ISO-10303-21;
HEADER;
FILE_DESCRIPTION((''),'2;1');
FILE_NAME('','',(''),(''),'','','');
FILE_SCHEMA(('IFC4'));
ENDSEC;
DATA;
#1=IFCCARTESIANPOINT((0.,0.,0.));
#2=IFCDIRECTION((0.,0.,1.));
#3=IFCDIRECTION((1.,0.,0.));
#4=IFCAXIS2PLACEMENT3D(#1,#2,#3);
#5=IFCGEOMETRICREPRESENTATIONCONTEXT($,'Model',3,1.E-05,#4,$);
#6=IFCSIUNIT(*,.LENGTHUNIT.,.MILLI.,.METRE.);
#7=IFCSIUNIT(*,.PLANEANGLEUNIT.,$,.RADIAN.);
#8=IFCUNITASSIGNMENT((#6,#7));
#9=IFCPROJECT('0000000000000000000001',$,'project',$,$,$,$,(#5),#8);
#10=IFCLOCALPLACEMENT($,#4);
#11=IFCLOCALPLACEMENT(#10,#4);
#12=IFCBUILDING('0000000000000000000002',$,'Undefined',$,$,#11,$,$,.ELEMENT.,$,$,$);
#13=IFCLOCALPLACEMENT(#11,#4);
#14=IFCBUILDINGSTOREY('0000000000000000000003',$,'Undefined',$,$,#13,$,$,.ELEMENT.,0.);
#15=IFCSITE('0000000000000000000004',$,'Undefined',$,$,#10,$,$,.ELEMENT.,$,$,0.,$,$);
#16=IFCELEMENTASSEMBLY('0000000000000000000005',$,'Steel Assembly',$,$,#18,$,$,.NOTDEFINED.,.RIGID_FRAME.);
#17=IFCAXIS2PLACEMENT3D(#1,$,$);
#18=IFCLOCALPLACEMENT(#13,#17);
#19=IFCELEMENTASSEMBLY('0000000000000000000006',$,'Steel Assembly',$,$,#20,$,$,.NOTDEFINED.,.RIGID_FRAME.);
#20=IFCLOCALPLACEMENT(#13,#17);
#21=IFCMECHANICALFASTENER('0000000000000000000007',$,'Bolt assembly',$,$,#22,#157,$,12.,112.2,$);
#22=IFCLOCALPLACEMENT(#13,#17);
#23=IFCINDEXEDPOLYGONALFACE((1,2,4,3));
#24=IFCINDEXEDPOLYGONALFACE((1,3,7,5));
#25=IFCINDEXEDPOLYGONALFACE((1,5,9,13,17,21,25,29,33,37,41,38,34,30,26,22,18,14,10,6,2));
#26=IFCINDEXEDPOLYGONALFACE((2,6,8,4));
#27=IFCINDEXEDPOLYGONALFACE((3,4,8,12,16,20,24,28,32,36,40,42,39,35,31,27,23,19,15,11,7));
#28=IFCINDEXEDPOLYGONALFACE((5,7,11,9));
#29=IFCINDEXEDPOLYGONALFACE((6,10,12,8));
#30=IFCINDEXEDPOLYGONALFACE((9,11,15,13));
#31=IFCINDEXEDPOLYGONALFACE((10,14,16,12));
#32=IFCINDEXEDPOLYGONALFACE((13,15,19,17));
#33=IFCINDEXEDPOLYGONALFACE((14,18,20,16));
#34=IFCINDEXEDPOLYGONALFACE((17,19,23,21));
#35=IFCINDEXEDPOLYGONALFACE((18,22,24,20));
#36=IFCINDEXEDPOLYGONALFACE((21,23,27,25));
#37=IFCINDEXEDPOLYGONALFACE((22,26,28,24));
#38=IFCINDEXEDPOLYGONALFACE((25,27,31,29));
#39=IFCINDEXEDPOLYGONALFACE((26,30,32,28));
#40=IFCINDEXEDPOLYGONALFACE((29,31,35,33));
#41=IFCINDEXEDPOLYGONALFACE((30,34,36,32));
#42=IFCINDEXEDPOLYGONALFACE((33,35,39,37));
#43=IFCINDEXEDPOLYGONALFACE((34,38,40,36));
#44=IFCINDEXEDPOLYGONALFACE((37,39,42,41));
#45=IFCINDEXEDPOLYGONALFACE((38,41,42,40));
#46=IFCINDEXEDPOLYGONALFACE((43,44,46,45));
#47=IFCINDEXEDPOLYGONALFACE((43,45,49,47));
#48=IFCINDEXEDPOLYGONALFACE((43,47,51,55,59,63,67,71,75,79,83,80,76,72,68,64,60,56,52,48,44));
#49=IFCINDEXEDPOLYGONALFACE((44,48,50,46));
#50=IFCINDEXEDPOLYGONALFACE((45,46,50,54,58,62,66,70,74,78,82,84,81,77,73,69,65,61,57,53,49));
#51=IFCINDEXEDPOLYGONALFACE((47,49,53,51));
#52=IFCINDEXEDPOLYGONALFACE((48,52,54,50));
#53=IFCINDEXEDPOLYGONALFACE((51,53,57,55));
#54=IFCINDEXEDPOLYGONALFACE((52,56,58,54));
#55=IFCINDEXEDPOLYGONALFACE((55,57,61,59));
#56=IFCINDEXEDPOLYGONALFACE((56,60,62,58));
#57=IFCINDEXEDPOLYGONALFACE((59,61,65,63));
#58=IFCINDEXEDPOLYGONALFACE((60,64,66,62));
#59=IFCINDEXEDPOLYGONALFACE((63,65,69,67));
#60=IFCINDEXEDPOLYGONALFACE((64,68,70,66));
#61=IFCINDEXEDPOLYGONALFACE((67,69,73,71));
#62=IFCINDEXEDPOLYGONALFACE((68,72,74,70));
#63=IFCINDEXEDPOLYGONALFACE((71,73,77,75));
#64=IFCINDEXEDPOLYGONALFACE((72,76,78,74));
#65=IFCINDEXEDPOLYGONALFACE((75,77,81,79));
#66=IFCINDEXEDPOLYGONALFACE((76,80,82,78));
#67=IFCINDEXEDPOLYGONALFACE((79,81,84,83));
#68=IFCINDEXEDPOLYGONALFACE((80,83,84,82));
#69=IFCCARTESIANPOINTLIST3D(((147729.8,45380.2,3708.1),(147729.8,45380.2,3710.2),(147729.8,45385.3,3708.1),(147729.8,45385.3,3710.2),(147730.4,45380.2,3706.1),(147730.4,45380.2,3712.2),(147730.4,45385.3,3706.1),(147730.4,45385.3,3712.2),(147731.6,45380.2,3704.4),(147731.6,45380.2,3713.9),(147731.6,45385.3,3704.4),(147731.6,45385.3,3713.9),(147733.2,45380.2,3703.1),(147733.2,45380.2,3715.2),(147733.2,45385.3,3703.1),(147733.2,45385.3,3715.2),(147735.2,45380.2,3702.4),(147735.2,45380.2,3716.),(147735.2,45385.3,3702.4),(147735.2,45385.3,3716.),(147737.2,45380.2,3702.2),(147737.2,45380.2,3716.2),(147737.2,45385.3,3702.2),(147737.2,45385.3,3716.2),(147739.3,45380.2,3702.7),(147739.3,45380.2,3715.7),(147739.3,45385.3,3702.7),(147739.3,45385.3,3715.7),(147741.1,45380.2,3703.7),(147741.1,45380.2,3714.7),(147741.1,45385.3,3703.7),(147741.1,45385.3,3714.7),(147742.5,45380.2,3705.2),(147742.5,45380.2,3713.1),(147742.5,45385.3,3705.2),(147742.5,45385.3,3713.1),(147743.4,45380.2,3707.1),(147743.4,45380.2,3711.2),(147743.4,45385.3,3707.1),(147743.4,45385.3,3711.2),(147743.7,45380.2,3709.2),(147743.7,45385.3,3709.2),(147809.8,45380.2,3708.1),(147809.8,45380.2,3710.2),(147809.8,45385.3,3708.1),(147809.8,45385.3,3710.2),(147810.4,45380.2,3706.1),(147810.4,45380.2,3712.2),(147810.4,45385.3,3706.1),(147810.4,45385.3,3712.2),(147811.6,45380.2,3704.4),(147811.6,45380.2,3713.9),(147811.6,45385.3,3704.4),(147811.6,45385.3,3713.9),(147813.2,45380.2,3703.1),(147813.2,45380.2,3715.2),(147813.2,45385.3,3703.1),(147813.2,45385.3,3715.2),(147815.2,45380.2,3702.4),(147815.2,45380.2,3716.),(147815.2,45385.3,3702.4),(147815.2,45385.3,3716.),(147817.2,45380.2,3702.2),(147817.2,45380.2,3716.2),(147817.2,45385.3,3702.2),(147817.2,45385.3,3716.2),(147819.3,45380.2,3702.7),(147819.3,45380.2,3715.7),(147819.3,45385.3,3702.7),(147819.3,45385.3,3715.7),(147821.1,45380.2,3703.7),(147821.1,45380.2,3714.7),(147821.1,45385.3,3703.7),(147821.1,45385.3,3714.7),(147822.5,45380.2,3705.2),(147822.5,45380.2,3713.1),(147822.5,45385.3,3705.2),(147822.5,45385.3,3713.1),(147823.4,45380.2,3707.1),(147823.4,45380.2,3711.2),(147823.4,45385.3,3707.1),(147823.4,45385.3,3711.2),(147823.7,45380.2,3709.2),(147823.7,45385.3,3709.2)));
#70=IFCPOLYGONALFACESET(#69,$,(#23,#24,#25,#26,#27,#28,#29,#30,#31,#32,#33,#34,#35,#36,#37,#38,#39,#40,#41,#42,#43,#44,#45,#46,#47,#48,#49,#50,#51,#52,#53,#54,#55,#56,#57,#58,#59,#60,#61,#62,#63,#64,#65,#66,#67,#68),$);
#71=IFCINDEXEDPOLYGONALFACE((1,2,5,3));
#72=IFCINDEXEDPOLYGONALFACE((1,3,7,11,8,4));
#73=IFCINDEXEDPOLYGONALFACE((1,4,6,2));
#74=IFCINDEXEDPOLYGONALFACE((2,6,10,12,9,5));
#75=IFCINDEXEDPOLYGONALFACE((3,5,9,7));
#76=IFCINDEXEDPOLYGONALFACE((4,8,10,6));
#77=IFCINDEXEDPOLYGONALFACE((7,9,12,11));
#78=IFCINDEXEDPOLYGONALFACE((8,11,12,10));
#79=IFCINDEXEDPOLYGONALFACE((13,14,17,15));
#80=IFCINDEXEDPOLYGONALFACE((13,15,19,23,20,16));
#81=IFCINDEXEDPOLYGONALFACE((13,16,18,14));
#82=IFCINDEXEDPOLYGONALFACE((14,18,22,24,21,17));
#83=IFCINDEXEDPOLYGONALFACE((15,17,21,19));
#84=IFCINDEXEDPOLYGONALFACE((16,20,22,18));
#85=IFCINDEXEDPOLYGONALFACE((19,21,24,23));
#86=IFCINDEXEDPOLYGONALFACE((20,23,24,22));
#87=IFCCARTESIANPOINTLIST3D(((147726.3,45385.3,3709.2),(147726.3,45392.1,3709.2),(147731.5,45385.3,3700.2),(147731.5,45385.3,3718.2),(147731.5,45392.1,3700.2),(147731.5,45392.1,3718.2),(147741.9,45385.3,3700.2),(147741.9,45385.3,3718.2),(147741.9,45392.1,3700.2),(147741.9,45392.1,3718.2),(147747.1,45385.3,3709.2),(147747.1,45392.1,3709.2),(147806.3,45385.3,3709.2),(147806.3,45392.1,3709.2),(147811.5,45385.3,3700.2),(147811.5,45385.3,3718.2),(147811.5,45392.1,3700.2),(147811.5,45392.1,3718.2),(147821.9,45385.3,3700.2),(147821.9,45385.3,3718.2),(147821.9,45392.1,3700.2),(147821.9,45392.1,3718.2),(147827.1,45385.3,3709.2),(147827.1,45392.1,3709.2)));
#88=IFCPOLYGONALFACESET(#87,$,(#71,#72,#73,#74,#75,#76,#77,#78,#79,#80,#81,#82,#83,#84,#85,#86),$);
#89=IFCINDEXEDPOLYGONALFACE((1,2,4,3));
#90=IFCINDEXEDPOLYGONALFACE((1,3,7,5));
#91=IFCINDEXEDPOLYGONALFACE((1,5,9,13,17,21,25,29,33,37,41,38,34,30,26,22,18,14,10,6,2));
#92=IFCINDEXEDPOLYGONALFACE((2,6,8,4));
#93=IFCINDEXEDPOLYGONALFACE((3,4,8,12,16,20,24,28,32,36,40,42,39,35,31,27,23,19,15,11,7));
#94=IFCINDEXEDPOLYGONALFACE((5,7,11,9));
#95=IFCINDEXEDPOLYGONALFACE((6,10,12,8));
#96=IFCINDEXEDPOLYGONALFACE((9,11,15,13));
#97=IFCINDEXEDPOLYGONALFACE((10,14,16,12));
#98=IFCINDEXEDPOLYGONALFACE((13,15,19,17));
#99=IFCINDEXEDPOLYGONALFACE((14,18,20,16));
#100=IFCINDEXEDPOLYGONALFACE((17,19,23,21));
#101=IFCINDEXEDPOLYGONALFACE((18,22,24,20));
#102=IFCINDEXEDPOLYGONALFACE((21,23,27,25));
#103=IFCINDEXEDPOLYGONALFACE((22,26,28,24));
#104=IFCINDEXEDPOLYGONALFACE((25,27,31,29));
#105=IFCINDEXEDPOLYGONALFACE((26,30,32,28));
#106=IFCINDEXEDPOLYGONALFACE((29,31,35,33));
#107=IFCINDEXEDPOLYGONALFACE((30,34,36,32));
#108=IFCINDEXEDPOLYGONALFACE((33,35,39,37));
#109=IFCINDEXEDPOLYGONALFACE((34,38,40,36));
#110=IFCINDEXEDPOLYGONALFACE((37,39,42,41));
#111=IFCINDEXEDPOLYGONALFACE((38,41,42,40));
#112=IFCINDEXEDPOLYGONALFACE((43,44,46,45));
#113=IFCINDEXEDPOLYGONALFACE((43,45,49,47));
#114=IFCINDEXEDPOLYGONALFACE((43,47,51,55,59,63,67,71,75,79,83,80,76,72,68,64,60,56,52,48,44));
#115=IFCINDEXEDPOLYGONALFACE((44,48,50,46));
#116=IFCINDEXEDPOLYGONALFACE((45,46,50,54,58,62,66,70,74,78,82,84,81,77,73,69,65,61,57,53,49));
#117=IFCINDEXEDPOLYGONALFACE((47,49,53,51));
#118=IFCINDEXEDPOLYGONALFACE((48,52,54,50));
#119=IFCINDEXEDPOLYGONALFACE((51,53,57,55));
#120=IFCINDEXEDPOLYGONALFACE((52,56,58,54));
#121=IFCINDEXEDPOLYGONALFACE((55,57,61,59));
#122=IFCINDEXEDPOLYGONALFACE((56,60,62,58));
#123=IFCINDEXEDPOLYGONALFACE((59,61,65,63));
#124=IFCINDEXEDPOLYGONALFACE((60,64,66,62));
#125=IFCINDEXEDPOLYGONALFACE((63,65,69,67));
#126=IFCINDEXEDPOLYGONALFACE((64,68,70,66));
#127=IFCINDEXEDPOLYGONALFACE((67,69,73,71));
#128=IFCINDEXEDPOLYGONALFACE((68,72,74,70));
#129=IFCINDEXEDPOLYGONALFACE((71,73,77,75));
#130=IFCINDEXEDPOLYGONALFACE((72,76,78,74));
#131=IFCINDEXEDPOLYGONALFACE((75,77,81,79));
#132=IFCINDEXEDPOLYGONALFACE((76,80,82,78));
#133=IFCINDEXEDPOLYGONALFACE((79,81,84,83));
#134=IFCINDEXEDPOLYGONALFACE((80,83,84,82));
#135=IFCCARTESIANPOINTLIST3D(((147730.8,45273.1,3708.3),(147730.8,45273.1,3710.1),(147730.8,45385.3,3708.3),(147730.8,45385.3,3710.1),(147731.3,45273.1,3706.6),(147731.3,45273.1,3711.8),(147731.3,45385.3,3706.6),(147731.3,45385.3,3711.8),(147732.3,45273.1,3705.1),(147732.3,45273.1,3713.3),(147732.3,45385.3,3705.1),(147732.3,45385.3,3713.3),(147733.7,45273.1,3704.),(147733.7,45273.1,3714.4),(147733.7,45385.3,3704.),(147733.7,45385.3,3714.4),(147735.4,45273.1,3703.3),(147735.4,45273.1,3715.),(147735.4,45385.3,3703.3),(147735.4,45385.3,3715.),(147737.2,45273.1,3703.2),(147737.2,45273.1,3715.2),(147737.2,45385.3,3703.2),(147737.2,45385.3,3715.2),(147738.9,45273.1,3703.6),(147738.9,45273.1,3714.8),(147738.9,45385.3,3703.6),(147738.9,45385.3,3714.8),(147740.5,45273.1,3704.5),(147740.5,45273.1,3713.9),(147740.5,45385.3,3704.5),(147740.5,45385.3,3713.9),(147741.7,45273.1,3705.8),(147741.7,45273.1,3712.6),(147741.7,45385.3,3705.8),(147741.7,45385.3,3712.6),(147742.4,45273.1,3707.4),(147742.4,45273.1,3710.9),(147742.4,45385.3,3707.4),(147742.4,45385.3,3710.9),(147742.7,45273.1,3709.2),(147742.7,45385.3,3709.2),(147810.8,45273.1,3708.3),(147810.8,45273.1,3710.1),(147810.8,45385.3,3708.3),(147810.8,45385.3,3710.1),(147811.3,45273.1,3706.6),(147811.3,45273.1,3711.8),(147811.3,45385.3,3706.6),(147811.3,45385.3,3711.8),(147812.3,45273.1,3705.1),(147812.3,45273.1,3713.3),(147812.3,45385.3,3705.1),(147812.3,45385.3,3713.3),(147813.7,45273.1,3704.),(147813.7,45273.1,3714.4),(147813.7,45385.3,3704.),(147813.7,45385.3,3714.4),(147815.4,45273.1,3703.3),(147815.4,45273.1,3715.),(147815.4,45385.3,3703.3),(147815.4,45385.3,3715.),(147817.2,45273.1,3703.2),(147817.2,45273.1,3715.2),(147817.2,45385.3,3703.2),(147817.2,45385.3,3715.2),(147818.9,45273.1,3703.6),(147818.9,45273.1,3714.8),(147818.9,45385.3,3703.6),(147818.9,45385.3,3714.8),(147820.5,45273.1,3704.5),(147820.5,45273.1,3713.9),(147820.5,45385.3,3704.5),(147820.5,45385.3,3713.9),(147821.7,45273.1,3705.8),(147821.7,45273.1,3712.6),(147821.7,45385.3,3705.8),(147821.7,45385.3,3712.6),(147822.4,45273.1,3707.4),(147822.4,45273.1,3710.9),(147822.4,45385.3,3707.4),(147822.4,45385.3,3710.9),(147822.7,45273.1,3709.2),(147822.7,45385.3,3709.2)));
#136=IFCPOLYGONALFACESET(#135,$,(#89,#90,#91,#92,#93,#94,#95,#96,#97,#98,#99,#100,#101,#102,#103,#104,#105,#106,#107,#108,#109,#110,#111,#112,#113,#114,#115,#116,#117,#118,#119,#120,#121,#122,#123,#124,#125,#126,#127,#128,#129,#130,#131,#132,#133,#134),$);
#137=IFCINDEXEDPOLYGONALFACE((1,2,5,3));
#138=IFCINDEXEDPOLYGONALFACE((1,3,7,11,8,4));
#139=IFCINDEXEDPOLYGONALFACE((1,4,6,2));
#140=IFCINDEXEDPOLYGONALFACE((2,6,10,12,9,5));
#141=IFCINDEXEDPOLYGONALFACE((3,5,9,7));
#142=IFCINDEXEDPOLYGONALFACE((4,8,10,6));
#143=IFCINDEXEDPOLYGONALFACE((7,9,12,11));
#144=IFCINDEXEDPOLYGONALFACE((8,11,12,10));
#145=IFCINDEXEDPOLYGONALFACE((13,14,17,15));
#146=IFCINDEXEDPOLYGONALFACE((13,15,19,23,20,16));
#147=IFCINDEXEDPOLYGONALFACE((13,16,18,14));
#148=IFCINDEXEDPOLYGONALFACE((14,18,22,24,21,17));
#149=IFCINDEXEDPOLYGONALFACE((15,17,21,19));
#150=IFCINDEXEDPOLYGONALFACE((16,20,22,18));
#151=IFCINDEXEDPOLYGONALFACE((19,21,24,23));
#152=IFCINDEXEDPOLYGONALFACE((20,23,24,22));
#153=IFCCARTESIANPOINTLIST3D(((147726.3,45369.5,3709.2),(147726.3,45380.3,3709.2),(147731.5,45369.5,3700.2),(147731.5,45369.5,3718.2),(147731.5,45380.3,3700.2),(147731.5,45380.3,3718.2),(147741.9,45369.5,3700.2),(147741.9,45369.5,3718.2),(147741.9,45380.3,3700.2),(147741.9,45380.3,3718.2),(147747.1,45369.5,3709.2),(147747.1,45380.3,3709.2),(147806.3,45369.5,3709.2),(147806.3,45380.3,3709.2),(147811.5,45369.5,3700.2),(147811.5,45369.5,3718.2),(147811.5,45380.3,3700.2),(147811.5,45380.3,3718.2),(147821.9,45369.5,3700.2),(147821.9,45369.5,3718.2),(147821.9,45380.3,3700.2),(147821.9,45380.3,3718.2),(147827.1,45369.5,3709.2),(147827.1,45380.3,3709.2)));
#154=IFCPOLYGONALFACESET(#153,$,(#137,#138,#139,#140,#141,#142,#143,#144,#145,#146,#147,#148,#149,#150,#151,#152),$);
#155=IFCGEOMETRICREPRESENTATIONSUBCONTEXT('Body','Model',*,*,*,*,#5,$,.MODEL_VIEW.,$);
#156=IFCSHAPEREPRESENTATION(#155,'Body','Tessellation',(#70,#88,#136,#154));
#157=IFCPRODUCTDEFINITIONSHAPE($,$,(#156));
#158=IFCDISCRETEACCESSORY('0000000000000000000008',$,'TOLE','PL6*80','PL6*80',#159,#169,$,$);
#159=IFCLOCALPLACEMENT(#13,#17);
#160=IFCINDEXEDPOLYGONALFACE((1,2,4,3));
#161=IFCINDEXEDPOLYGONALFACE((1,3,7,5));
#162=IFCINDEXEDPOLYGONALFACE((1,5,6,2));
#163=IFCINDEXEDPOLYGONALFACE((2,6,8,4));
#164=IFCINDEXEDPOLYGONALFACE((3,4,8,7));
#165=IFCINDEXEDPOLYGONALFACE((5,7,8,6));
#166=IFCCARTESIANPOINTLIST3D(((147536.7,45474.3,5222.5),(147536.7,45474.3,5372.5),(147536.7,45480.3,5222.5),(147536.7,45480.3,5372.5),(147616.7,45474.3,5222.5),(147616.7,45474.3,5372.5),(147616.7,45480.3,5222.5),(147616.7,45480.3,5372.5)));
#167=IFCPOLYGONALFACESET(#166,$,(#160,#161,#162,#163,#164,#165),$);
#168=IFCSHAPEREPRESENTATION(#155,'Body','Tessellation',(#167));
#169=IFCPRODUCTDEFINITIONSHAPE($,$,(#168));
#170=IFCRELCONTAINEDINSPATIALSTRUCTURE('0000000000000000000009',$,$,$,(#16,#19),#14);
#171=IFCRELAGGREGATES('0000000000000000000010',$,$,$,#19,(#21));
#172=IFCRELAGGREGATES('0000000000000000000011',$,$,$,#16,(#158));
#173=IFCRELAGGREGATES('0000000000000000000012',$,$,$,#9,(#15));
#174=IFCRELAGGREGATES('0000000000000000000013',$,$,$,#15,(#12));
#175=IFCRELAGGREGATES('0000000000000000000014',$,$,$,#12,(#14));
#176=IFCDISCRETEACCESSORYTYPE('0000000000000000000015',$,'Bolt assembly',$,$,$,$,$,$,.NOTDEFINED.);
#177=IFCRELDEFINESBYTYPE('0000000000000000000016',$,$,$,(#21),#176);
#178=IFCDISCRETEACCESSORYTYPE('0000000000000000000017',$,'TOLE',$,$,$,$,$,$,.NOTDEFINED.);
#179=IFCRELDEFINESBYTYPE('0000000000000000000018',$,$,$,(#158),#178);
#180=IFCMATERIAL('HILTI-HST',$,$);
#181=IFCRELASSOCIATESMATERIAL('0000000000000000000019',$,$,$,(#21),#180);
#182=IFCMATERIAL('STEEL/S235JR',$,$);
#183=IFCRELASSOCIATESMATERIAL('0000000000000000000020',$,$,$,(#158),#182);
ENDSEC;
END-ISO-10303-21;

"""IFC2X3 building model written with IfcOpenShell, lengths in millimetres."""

from ifc_helpers import new_model, si_unit, frame, origin_with_axes, origin_2d_with_axis, place, context, subcontext, project, spatial, polyline, circle, outline, extrude, source, transform, mapped, material, type_object, element, aggregate, save


model = new_model("IFC2X3")

# Units and contexts
model_context = context("Model", 3, precision=1e-05, world=origin_with_axes())
body_context = subcontext(model_context, "Body", "Model", "MODEL_VIEW")
ifc_project = project(units=[si_unit("LENGTHUNIT", "METRE", prefix="MILLI"), si_unit("PLANEANGLEUNIT", "RADIAN")], contexts=[model_context])

# Site, building, storey
site_placement = place(None, origin_with_axes())
site = spatial("IfcSite", under=ifc_project, at=site_placement, Name="Undefined", CompositionType="ELEMENT", RefElevation=0.0)
building_placement = place(site_placement, origin_with_axes())
building = spatial("IfcBuilding", under=site, at=building_placement, Name="Undefined", CompositionType="ELEMENT")
storey_placement = place(building_placement, origin_with_axes())
storey = spatial("IfcBuildingStorey", under=building, at=storey_placement, Name="Undefined", CompositionType="ELEMENT", Elevation=0.0)

# Element assembly
ifc_material_1 = material(Name="STEEL/S235JR")
assembly_1_placement = place(storey_placement, origin_with_axes())
assembly_1 = element("IfcElementAssembly", 1, at=assembly_1_placement, inside=storey, Name="Steel Assembly", AssemblyPlace="NOTDEFINED", PredefinedType="RIGID_FRAME")

# Element assembly
assembly_2_placement = place(storey_placement, origin_with_axes())
assembly_2 = element("IfcElementAssembly", 2, at=assembly_2_placement, inside=storey, Name="Steel Assembly", AssemblyPlace="NOTDEFINED", PredefinedType="RIGID_FRAME")

# Mechanical fastener
ifc_material_2 = material(Name="HILTI-HST")
discrete_accessory_type_1 = type_object("IfcDiscreteAccessoryType", Name="Bolt assembly")
shared_shape_1 = source(origin_with_axes(), body_context, "Body", "SweptSolid", [
    extrude(circle(Radius=7.0, at=origin_2d_with_axis()), frame((0.0, 0.0, 0.0), z_axis=(0.0, 1.0, 0.0), x_axis=(1.0, 0.0, 0.0)), (0.0, 0.0, 1.0), 5.1),
    extrude(outline(polyline([(10.4, 0.0), (5.2, 9.0), (-5.2, 9.0), (-10.4, 0.0), (-5.2, -9.0), (5.2, -9.0), (10.4, 0.0)])), frame((0.0, -6.8, 0.0), z_axis=(0.0, 1.0, 0.0), x_axis=(1.0, 0.0, 0.0)), (0.0, 0.0, 1.0), 6.8),
    extrude(circle(Radius=6.0, at=origin_2d_with_axis()), frame((0.0, 0.0, 0.0), z_axis=(0.0, 1.0, 0.0), x_axis=(1.0, 0.0, 0.0)), (0.0, 0.0, 1.0), 112.2),
    extrude(outline(polyline([(10.4, 0.0), (5.2, 9.0), (-5.2, 9.0), (-10.4, 0.0), (-5.2, -9.0), (5.2, -9.0), (10.4, 0.0)])), frame((0.0, 5.0, 0.0), z_axis=(0.0, 1.0, 0.0), x_axis=(1.0, 0.0, 0.0)), (0.0, 0.0, 1.0), 10.8),
])
mechanical_fastener_1_placement = place(assembly_2_placement, frame((147736.7, 45385.3, 3709.2), z_axis=(0.0, 0.0, -1.0), x_axis=(1.0, 0.0, 0.0)))
mechanical_fastener_1 = element("IfcMechanicalFastener", 3, at=mechanical_fastener_1_placement, type_object=discrete_accessory_type_1, material=ifc_material_2, Name="Bolt assembly", NominalDiameter=12.0, NominalLength=112.2, context=body_context, shape_type="MappedRepresentation", body=[
    mapped(shared_shape_1, transform((0.0, 0.0, 0.0))),
    mapped(shared_shape_1, transform((80.0, 0.0, 0.0))),
])
aggregate(assembly_2, [mechanical_fastener_1])

# Discrete accessory
discrete_accessory_type_2 = type_object("IfcDiscreteAccessoryType", Name="TOLE")
discrete_accessory_1_placement = place(assembly_1_placement, frame((147576.7, 45477.3, 5372.5), z_axis=(0.0, -1.0, 0.0), x_axis=(0.0, 0.0, -1.0)))
discrete_accessory_1 = element("IfcDiscreteAccessory", 4, at=discrete_accessory_1_placement, type_object=discrete_accessory_type_2, material=ifc_material_1, Name="TOLE", Description="PL6*80", ObjectType="PL6*80", context=body_context, shape_type="SweptSolid", body=[
    extrude(outline(polyline([(0.0, -40.0), (0.0, 40.0), (150.0, 40.0), (150.0, -40.0), (0.0, -40.0)])), frame((0.0, 0.0, -3.0), z_axis=(0.0, 0.0, 1.0), x_axis=(1.0, 0.0, 0.0)), (0.0, 0.0, 1.0), 6.0),
])

aggregate(assembly_1, [discrete_accessory_1])

save(model, "model.ifc")
